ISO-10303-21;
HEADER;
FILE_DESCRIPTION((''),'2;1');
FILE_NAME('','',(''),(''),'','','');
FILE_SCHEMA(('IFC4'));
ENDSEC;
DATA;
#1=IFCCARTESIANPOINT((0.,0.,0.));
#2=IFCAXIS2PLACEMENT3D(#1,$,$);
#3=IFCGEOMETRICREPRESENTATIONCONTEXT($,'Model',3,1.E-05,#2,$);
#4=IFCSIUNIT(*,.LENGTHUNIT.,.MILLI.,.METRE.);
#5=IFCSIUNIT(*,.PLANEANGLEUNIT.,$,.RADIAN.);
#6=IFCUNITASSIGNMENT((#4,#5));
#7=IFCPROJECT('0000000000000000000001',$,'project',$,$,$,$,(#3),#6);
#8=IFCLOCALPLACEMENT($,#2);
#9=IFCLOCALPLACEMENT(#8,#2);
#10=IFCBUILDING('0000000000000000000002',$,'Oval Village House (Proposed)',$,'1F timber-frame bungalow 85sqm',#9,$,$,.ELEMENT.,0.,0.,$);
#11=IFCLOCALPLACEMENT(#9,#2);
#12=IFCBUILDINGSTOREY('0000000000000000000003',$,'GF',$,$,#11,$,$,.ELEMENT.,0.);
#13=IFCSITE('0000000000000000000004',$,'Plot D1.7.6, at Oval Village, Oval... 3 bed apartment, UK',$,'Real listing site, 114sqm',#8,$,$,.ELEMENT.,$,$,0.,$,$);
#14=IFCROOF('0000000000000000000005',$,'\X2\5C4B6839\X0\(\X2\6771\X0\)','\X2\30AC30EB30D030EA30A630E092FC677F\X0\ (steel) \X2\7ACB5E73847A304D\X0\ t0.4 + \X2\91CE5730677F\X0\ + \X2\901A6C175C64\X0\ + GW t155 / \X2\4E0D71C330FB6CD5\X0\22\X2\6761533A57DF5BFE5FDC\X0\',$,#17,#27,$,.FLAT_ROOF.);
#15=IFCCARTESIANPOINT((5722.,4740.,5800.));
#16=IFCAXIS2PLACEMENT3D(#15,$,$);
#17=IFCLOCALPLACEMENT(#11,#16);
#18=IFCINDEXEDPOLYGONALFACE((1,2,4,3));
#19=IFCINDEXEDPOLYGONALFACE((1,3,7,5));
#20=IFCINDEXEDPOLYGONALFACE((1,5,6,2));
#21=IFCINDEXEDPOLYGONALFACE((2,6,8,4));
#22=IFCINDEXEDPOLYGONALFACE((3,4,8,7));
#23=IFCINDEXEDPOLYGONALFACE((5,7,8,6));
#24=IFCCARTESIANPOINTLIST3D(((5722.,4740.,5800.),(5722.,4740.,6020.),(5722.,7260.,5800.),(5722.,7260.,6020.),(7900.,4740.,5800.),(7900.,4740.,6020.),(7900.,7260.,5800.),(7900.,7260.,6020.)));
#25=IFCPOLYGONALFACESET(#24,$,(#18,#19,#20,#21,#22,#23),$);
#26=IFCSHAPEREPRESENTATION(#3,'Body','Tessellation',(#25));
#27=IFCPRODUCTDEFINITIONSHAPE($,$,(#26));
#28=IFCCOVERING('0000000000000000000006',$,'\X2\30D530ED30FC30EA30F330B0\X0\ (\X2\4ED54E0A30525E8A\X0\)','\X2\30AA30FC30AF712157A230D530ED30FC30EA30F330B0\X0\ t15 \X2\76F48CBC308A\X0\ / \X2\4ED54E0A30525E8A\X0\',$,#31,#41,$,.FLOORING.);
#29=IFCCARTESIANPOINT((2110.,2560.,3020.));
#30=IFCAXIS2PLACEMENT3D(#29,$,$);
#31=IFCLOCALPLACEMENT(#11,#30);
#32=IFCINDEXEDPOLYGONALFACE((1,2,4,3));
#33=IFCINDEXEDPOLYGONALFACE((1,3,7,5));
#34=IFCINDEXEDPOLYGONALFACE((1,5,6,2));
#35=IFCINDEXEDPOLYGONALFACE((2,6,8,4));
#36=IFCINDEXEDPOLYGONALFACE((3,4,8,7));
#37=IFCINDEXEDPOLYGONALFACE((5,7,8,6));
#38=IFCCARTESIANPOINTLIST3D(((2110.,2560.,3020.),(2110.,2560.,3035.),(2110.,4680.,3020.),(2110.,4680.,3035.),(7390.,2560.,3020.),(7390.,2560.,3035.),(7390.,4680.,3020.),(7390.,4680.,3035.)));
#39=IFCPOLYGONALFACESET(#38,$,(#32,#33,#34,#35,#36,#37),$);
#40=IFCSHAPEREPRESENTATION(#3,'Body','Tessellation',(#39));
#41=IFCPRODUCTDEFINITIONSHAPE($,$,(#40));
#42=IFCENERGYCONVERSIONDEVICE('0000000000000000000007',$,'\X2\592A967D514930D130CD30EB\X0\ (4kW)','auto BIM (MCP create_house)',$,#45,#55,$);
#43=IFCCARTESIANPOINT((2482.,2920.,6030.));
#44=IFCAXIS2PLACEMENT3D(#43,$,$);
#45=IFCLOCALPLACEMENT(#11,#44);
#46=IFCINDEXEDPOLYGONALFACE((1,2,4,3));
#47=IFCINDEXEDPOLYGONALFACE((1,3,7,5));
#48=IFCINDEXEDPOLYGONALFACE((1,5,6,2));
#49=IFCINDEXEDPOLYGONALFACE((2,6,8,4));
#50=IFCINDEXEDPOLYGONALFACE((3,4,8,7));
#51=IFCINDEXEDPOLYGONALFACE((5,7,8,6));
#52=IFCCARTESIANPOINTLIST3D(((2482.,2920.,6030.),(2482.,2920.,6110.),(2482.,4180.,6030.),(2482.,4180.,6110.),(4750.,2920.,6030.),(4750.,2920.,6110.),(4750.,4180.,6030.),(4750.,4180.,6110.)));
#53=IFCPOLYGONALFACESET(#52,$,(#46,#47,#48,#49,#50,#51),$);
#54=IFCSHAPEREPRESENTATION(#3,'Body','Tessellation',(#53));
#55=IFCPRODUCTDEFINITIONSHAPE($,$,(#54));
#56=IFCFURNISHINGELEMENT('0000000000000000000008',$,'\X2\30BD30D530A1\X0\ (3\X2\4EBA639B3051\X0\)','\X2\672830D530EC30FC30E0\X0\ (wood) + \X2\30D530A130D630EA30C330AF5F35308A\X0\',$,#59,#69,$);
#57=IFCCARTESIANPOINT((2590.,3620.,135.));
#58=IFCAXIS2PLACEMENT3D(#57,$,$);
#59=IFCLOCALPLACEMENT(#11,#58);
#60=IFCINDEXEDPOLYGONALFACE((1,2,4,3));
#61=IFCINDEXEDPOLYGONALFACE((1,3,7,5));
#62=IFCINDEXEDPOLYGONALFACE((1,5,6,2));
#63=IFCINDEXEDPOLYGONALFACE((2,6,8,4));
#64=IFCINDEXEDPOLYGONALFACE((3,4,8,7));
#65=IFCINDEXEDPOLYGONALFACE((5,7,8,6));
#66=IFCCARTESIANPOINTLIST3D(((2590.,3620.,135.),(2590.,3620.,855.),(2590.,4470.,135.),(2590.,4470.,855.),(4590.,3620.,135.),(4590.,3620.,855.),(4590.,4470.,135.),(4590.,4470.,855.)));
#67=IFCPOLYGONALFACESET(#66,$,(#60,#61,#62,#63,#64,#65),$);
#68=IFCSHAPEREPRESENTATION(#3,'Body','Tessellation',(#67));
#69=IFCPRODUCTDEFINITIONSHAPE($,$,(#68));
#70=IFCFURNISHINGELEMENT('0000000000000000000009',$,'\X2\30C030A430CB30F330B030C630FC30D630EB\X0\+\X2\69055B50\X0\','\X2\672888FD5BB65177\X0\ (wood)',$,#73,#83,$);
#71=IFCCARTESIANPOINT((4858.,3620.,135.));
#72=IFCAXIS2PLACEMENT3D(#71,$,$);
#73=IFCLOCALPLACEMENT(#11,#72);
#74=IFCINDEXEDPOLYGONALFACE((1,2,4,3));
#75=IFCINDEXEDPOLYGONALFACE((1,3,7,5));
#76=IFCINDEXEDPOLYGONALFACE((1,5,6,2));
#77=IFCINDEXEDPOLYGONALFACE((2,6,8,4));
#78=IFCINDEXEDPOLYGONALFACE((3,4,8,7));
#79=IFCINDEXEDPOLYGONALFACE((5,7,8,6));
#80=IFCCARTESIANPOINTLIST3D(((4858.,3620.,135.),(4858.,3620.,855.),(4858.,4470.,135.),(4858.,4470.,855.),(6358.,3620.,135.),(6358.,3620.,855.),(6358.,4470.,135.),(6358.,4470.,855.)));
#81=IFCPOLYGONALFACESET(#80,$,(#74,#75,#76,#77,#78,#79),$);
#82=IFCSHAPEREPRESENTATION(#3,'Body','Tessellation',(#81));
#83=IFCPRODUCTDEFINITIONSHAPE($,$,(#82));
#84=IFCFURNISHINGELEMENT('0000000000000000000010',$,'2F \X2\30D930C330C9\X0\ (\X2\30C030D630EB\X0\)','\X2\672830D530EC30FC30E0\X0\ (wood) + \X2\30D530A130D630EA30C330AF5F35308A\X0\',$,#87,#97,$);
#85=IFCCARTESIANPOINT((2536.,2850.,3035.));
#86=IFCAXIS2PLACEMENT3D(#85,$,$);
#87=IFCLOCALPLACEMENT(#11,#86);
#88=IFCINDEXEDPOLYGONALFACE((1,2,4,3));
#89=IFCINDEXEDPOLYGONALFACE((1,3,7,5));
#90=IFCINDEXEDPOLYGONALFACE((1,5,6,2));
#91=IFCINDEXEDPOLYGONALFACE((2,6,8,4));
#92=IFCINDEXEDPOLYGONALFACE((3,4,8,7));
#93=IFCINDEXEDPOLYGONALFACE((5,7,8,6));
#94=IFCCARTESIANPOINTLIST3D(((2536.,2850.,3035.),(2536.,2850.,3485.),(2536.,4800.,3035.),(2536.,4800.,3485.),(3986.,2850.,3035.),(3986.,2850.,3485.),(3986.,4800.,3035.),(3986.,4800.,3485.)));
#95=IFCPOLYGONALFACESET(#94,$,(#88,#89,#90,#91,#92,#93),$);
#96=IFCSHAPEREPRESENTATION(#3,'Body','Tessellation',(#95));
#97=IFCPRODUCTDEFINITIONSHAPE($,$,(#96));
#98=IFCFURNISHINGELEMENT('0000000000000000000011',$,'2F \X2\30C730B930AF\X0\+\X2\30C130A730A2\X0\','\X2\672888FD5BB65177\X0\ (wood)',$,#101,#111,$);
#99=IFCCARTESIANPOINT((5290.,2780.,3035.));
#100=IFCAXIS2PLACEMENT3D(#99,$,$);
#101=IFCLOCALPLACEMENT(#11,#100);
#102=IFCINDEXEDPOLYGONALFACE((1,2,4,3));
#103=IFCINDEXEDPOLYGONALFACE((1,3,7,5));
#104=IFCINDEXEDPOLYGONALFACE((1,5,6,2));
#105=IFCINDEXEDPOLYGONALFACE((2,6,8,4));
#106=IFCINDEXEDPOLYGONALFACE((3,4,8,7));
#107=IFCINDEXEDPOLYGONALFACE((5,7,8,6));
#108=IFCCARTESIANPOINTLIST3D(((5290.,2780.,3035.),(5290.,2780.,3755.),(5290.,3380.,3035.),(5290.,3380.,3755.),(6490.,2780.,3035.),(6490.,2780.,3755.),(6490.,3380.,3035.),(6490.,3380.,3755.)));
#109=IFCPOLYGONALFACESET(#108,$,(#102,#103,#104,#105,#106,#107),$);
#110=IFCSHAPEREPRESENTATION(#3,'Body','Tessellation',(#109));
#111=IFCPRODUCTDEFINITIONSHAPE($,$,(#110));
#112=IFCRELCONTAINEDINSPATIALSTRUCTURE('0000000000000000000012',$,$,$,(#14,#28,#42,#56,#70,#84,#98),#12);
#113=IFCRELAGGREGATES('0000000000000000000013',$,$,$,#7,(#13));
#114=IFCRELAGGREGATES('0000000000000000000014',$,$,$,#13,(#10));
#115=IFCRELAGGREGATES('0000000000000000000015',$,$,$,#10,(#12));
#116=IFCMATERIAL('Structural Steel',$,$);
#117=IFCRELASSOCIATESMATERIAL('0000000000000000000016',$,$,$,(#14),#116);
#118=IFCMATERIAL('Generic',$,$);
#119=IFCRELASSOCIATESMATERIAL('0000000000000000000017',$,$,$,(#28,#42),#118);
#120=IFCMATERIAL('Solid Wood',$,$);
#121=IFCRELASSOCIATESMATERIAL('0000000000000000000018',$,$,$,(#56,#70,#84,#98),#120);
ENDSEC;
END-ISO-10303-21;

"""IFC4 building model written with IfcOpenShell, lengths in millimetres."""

from ifc_helpers import new_model, si_unit, frame, frame_2d, origin, place, context, project, spatial, rectangle, extrude, material, element, save


model = new_model("IFC4")

# Units and contexts
model_context = context("Model", 3, precision=1e-05, world=origin())
ifc_project = project(units=[si_unit("LENGTHUNIT", "METRE", prefix="MILLI"), si_unit("PLANEANGLEUNIT", "RADIAN")], contexts=[model_context])

# Site, building, storey
site_placement = place(None, origin())
site = spatial("IfcSite", under=ifc_project, at=site_placement, Name="Plot D1.7.6, at Oval Village, Oval... 3 bed apartment, UK", ObjectType="Real listing site, 114sqm", CompositionType="ELEMENT", RefElevation=0.0)
building_placement = place(site_placement, origin())
building = spatial("IfcBuilding", under=site, at=building_placement, Name="Oval Village House (Proposed)", ObjectType="1F timber-frame bungalow 85sqm", CompositionType="ELEMENT", ElevationOfRefHeight=0.0, ElevationOfTerrain=0.0)
storey_placement = place(building_placement, origin())
storey = spatial("IfcBuildingStorey", under=building, at=storey_placement, Name="GF", CompositionType="ELEMENT", Elevation=0.0)

# Shared definitions
ifc_material_1 = material(Name="Solid Wood")

# Roof
ifc_material_2 = material(Name="Structural Steel")
roof_1_placement = place(storey_placement, frame((5722.0, 4740.0, 5800.0)))
element("IfcRoof", 1, at=roof_1_placement, inside=storey, material=ifc_material_2, Name="屋根(東)", Description="ガルバリウム鋼板 (steel) 立平葺き t0.4 + 野地板 + 通気層 + GW t155 / 不燃・法22条区域対応", PredefinedType="FLAT_ROOF", context=model_context, shape_type="SweptSolid", body=[
    extrude(rectangle(XDim=2178.0, YDim=2520.0, at=frame_2d((1089.0, 1260.0))), frame((5722.0, 4740.0, 5800.0)), (0.0, 0.0, 1.0), 220.0),
])

# Covering
ifc_material_3 = material(Name="Generic")
covering_placement = place(storey_placement, frame((2110.0, 2560.0, 3020.0)))
element("IfcCovering", 2, at=covering_placement, inside=storey, material=ifc_material_3, Name="フローリング (仕上げ床)", Description="オーク無垢フローリング t15 直貼り / 仕上げ床", PredefinedType="FLOORING", context=model_context, shape_type="SweptSolid", body=[
    extrude(rectangle(XDim=5280.0, YDim=2120.0, at=frame_2d((2640.0, 1060.0))), frame((2110.0, 2560.0, 3020.0)), (0.0, 0.0, 1.0), 15.0),
])

# Energy conversion device
energy_conversion_device_placement = place(storey_placement, frame((2482.0, 2920.0, 6030.0)))
element("IfcEnergyConversionDevice", 3, at=energy_conversion_device_placement, inside=storey, material=ifc_material_3, Name="太陽光パネル (4kW)", Description="auto BIM (MCP create_house)", context=model_context, shape_type="SweptSolid", body=[
    extrude(rectangle(XDim=2268.0, YDim=1260.0, at=frame_2d((1134.0, 630.0))), frame((2482.0, 2920.0, 6030.0)), (0.0, 0.0, 1.0), 80.0),
])

# Furnishing elements
furnishing_1_placement = place(storey_placement, frame((2590.0, 3620.0, 135.0)))
element("IfcFurnishingElement", 4, at=furnishing_1_placement, inside=storey, material=ifc_material_1, Name="ソファ (3人掛け)", Description="木フレーム (wood) + ファブリック張り", context=model_context, shape_type="SweptSolid", body=[
    extrude(rectangle(XDim=2000.0, YDim=850.0, at=frame_2d((1000.0, 425.0))), frame((2590.0, 3620.0, 135.0)), (0.0, 0.0, 1.0), 720.0),
])
furnishing_2_placement = place(storey_placement, frame((4858.0, 3620.0, 135.0)))
element("IfcFurnishingElement", 5, at=furnishing_2_placement, inside=storey, material=ifc_material_1, Name="ダイニングテーブル+椅子", Description="木製家具 (wood)", context=model_context, shape_type="SweptSolid", body=[
    extrude(rectangle(XDim=1500.0, YDim=850.0, at=frame_2d((750.0, 425.0))), frame((4858.0, 3620.0, 135.0)), (0.0, 0.0, 1.0), 720.0),
])
furnishing_3_placement = place(storey_placement, frame((2536.0, 2850.0, 3035.0)))
element("IfcFurnishingElement", 6, at=furnishing_3_placement, inside=storey, material=ifc_material_1, Name="2F ベッド (ダブル)", Description="木フレーム (wood) + ファブリック張り", context=model_context, shape_type="SweptSolid", body=[
    extrude(rectangle(XDim=1450.0, YDim=1950.0, at=frame_2d((725.0, 975.0))), frame((2536.0, 2850.0, 3035.0)), (0.0, 0.0, 1.0), 450.0),
])
furnishing_4_placement = place(storey_placement, frame((5290.0, 2780.0, 3035.0)))
element("IfcFurnishingElement", 7, at=furnishing_4_placement, inside=storey, material=ifc_material_1, Name="2F デスク+チェア", Description="木製家具 (wood)", context=model_context, shape_type="SweptSolid", body=[
    extrude(rectangle(XDim=1200.0, YDim=600.0, at=frame_2d((600.0, 300.0))), frame((5290.0, 2780.0, 3035.0)), (0.0, 0.0, 1.0), 720.0),
])

save(model, "model.ifc")
